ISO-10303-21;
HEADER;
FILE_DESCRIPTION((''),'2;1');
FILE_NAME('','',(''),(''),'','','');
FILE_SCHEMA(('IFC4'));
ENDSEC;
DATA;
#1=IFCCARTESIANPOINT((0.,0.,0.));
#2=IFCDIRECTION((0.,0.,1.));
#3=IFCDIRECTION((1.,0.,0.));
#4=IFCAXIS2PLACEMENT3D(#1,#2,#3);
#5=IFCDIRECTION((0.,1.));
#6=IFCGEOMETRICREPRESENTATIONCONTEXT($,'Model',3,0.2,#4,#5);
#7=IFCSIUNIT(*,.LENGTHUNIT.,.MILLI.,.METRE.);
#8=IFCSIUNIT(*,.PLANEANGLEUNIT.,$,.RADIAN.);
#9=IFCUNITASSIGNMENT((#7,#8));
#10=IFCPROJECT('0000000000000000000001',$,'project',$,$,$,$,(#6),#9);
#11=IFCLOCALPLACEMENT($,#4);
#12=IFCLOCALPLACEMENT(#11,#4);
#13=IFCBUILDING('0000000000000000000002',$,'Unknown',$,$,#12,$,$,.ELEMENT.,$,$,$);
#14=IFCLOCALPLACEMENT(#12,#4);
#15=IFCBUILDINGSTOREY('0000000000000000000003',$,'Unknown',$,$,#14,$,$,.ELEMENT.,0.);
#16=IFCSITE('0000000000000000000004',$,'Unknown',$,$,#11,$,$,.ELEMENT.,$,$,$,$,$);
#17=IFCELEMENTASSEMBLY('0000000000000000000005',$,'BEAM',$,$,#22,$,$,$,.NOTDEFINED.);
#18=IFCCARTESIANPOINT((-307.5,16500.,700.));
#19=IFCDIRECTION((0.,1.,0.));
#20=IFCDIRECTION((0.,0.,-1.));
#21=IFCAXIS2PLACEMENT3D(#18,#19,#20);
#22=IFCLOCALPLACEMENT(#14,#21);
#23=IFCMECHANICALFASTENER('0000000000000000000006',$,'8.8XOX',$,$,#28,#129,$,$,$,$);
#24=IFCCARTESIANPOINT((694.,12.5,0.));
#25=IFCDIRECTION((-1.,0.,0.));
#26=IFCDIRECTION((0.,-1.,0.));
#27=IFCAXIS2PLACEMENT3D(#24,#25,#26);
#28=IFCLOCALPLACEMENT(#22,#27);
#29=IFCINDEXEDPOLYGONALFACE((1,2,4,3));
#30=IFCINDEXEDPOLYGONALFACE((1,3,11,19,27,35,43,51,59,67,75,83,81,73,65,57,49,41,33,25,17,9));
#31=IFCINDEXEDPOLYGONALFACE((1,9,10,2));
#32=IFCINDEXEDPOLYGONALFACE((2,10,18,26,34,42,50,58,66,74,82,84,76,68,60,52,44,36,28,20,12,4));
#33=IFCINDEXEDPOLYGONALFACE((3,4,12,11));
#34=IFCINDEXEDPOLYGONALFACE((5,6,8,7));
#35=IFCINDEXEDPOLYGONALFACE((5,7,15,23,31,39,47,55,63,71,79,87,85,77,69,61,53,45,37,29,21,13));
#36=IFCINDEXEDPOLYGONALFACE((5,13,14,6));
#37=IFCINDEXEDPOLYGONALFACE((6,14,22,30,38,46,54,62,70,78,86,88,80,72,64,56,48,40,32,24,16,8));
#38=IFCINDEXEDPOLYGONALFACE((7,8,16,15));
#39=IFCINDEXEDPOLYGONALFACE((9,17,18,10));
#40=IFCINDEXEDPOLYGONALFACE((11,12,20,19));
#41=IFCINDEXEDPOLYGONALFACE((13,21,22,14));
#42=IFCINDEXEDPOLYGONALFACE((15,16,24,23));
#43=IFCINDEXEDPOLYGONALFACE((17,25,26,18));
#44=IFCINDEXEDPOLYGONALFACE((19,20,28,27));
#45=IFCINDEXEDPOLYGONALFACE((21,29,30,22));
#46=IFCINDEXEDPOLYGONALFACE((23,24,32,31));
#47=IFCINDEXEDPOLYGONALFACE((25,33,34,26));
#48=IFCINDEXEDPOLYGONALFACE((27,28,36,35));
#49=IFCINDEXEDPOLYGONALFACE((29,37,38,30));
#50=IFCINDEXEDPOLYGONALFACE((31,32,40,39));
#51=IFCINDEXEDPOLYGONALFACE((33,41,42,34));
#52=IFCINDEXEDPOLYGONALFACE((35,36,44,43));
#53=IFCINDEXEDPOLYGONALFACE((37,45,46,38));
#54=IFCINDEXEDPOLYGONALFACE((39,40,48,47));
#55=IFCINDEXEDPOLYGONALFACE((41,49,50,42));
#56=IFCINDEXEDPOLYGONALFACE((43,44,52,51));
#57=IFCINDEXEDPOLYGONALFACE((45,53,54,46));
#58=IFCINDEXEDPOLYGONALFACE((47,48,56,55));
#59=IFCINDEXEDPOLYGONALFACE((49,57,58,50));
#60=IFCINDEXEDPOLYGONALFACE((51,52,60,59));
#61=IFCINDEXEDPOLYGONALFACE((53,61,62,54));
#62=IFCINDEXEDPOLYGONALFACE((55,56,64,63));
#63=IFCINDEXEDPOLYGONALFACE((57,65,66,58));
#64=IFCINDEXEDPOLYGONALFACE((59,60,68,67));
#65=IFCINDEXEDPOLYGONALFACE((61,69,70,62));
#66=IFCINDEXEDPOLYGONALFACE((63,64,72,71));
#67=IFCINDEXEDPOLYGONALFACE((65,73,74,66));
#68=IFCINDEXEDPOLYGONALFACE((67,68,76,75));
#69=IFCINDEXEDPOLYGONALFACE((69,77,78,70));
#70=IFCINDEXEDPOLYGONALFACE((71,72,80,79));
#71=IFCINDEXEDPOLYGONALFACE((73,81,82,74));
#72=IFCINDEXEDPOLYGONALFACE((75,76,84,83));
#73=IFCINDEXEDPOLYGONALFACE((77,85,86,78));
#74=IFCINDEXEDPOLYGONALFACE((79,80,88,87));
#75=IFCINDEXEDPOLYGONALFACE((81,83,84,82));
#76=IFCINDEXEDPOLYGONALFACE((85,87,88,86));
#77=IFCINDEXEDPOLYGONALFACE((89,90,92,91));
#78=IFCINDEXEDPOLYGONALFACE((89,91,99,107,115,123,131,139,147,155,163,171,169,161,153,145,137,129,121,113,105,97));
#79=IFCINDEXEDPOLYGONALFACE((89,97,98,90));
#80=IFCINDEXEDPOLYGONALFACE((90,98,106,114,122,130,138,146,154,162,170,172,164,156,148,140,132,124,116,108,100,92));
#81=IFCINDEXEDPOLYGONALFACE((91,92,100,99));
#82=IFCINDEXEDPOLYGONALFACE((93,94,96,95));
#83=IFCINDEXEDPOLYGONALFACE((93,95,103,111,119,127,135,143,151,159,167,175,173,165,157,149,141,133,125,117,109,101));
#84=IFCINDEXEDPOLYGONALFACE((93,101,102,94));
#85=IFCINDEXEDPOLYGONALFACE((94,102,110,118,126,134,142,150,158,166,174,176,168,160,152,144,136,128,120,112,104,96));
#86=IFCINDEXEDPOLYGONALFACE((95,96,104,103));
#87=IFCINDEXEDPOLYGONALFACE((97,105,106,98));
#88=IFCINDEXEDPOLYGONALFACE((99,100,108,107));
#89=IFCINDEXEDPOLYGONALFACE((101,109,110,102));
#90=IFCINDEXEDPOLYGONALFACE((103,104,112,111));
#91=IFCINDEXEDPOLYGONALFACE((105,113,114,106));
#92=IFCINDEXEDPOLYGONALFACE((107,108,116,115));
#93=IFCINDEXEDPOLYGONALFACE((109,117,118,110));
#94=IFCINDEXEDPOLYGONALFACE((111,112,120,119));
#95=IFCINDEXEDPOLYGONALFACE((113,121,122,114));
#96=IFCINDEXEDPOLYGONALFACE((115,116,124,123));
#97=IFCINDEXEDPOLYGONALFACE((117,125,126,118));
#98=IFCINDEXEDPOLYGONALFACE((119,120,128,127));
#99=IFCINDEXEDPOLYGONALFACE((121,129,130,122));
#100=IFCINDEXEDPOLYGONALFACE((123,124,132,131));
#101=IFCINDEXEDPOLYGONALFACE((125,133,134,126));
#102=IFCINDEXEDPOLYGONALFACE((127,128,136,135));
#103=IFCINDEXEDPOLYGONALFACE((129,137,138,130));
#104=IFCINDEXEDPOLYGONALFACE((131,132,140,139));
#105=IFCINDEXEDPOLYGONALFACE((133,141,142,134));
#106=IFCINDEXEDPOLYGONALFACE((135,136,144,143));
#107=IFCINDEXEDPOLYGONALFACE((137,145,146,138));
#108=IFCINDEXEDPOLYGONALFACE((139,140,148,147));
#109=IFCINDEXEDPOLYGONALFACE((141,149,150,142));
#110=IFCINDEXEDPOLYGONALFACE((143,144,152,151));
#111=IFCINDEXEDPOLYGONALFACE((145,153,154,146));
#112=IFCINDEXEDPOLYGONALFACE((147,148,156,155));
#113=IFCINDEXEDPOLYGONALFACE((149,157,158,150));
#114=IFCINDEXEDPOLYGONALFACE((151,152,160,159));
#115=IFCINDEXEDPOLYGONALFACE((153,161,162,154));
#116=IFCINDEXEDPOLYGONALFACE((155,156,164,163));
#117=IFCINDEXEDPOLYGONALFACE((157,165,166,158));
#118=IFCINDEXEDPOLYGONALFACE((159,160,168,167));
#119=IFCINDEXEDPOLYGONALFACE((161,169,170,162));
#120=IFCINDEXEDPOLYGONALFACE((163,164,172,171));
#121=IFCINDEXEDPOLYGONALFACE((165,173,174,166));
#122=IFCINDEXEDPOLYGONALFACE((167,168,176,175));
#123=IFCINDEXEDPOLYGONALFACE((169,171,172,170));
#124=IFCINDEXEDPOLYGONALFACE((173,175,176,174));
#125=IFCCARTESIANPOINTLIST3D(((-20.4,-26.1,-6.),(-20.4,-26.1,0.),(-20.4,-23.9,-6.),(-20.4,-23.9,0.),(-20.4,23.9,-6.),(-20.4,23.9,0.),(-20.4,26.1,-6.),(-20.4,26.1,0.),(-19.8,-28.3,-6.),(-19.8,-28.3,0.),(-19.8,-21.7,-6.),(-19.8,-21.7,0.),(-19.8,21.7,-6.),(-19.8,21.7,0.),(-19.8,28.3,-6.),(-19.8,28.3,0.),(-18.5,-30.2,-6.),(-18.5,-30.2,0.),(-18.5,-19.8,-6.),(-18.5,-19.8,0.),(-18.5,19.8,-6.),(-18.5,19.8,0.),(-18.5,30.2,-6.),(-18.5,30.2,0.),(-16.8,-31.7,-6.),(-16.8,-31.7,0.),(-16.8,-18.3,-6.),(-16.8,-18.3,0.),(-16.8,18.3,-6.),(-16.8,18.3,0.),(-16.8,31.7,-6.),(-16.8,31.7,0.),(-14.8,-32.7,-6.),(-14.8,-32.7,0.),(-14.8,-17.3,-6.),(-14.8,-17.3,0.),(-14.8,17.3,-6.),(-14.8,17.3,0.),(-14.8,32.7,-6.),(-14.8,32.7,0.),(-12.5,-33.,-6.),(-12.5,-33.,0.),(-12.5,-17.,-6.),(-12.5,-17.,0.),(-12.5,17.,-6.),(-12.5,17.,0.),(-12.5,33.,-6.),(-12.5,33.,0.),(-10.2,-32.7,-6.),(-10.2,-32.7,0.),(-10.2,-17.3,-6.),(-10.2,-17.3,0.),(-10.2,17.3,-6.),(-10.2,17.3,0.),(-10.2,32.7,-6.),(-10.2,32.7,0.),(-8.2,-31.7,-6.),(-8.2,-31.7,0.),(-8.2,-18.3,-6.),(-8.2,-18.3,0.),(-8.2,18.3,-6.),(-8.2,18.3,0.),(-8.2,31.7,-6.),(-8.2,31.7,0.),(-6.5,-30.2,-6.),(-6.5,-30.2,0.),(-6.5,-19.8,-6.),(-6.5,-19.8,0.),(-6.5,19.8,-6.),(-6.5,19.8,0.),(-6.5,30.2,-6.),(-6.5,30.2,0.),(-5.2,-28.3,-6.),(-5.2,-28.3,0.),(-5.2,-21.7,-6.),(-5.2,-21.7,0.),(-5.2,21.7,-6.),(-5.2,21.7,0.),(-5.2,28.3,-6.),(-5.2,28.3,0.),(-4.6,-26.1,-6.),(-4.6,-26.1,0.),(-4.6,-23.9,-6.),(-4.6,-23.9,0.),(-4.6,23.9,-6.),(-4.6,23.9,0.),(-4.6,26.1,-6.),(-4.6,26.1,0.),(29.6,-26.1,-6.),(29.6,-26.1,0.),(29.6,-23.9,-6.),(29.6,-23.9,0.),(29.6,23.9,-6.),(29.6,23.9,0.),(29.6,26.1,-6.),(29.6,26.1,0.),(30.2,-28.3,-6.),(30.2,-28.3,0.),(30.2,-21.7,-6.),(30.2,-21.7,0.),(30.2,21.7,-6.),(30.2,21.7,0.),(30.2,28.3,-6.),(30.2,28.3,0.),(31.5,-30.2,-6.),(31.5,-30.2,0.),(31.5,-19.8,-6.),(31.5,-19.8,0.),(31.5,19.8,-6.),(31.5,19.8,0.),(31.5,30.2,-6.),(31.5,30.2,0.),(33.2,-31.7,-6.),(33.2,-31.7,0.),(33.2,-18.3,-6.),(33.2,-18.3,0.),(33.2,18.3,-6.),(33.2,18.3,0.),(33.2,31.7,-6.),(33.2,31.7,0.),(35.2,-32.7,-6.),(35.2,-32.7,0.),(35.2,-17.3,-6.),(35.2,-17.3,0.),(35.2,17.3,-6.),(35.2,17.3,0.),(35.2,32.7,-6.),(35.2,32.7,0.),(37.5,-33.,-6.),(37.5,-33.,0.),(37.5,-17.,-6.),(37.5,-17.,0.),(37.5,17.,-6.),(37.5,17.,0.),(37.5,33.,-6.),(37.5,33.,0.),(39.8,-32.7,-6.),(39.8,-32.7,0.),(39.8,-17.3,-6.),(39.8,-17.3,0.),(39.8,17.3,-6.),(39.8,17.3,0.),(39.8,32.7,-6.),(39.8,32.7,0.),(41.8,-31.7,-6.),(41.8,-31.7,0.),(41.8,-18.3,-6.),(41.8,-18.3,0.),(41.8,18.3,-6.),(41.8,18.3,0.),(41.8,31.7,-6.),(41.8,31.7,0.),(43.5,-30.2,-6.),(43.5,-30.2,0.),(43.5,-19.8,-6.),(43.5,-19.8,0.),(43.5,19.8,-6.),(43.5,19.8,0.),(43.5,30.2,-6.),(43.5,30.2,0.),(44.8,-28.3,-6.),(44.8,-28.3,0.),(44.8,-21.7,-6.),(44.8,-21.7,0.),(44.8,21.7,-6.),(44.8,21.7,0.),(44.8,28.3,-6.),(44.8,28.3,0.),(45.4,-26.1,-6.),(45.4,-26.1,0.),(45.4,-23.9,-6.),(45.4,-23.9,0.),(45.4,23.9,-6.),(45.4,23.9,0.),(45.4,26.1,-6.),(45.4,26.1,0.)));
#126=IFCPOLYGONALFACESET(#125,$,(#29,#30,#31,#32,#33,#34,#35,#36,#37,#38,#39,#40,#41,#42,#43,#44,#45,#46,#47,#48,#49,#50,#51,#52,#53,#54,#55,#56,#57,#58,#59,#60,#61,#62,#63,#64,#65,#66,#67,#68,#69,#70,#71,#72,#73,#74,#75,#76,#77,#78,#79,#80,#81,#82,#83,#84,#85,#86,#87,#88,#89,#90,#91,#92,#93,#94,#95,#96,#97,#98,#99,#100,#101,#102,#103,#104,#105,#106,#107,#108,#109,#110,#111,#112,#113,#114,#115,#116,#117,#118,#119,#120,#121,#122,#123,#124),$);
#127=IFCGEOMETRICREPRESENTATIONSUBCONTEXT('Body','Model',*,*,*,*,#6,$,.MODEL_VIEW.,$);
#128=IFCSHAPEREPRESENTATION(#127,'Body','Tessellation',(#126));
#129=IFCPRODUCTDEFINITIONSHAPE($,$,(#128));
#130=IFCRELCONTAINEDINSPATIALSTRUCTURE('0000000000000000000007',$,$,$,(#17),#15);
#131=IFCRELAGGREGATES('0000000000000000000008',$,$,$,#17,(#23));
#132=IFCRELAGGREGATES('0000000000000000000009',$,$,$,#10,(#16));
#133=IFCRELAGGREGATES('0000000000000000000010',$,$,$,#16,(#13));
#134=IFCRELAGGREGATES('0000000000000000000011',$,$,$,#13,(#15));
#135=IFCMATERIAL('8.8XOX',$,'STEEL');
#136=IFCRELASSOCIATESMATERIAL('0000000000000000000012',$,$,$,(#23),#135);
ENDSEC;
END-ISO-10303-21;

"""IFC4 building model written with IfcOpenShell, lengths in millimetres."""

from ifc_helpers import new_model, si_unit, direction, frame, origin_with_axes, place, context, subcontext, project, spatial, arc, indexed_curve, outline, extrude, source, transform, mapped, material, element, aggregate, save


model = new_model("IFC4")

# Units and contexts
model_context = context("Model", 3, precision=0.2, world=origin_with_axes(), true_north=direction((0.0, 1.0)))
body_context = subcontext(model_context, "Body", "Model", "MODEL_VIEW")
ifc_project = project(units=[si_unit("LENGTHUNIT", "METRE", prefix="MILLI"), si_unit("PLANEANGLEUNIT", "RADIAN")], contexts=[model_context])

# Site, building, storey
site_placement = place(None, origin_with_axes())
site = spatial("IfcSite", under=ifc_project, at=site_placement, Name="Unknown", CompositionType="ELEMENT")
building_placement = place(site_placement, origin_with_axes())
building = spatial("IfcBuilding", under=site, at=building_placement, Name="Unknown", CompositionType="ELEMENT")
storey_placement = place(building_placement, origin_with_axes())
storey = spatial("IfcBuildingStorey", under=building, at=storey_placement, Name="Unknown", CompositionType="ELEMENT", Elevation=0.0)

# Element assembly
assembly_1_placement = place(storey_placement, frame((-307.5, 16500.0, 700.0), z_axis=(0.0, 1.0, 0.0), x_axis=(0.0, 0.0, -1.0)))
assembly_1 = element("IfcElementAssembly", 1, at=assembly_1_placement, inside=storey, Name="BEAM", PredefinedType="NOTDEFINED")

# Shared definitions
ifc_material_1 = material(Name="8.8XOX", Category="STEEL")

# Mechanical fastener
shared_shape_1 = source(origin_with_axes(), body_context, "Body", "SweptSolid", [
    extrude(outline(indexed_curve([(8.0, 0.0), (0.0, 8.0), (-8.0, 0.0), (0.0, -8.0)], segments=[arc(1, 2, 3), arc(3, 4, 1)])), frame((0.0, 0.0, 0.0), z_axis=(0.0, 0.0, -1.0), x_axis=(0.0, 1.0, 0.0)), (0.0, 0.0, 1.0), 6.0),
])
mechanical_fastener_1_placement = place(assembly_1_placement, frame((694.0, 12.5, 0.0), z_axis=(-1.0, 0.0, 0.0), x_axis=(0.0, -1.0, 0.0)))
mechanical_fastener_1 = element("IfcMechanicalFastener", 2, at=mechanical_fastener_1_placement, material=ifc_material_1, Name="8.8XOX", context=body_context, shape_type="MappedRepresentation", body=[
    mapped(shared_shape_1, transform((-12.5, 25.0, 0.0))),
    mapped(shared_shape_1, transform((-12.5, -25.0, 0.0))),
    mapped(shared_shape_1, transform((37.5, 25.0, 0.0))),
    mapped(shared_shape_1, transform((37.5, -25.0, 0.0))),
])
aggregate(assembly_1, [mechanical_fastener_1])

save(model, "model.ifc")
